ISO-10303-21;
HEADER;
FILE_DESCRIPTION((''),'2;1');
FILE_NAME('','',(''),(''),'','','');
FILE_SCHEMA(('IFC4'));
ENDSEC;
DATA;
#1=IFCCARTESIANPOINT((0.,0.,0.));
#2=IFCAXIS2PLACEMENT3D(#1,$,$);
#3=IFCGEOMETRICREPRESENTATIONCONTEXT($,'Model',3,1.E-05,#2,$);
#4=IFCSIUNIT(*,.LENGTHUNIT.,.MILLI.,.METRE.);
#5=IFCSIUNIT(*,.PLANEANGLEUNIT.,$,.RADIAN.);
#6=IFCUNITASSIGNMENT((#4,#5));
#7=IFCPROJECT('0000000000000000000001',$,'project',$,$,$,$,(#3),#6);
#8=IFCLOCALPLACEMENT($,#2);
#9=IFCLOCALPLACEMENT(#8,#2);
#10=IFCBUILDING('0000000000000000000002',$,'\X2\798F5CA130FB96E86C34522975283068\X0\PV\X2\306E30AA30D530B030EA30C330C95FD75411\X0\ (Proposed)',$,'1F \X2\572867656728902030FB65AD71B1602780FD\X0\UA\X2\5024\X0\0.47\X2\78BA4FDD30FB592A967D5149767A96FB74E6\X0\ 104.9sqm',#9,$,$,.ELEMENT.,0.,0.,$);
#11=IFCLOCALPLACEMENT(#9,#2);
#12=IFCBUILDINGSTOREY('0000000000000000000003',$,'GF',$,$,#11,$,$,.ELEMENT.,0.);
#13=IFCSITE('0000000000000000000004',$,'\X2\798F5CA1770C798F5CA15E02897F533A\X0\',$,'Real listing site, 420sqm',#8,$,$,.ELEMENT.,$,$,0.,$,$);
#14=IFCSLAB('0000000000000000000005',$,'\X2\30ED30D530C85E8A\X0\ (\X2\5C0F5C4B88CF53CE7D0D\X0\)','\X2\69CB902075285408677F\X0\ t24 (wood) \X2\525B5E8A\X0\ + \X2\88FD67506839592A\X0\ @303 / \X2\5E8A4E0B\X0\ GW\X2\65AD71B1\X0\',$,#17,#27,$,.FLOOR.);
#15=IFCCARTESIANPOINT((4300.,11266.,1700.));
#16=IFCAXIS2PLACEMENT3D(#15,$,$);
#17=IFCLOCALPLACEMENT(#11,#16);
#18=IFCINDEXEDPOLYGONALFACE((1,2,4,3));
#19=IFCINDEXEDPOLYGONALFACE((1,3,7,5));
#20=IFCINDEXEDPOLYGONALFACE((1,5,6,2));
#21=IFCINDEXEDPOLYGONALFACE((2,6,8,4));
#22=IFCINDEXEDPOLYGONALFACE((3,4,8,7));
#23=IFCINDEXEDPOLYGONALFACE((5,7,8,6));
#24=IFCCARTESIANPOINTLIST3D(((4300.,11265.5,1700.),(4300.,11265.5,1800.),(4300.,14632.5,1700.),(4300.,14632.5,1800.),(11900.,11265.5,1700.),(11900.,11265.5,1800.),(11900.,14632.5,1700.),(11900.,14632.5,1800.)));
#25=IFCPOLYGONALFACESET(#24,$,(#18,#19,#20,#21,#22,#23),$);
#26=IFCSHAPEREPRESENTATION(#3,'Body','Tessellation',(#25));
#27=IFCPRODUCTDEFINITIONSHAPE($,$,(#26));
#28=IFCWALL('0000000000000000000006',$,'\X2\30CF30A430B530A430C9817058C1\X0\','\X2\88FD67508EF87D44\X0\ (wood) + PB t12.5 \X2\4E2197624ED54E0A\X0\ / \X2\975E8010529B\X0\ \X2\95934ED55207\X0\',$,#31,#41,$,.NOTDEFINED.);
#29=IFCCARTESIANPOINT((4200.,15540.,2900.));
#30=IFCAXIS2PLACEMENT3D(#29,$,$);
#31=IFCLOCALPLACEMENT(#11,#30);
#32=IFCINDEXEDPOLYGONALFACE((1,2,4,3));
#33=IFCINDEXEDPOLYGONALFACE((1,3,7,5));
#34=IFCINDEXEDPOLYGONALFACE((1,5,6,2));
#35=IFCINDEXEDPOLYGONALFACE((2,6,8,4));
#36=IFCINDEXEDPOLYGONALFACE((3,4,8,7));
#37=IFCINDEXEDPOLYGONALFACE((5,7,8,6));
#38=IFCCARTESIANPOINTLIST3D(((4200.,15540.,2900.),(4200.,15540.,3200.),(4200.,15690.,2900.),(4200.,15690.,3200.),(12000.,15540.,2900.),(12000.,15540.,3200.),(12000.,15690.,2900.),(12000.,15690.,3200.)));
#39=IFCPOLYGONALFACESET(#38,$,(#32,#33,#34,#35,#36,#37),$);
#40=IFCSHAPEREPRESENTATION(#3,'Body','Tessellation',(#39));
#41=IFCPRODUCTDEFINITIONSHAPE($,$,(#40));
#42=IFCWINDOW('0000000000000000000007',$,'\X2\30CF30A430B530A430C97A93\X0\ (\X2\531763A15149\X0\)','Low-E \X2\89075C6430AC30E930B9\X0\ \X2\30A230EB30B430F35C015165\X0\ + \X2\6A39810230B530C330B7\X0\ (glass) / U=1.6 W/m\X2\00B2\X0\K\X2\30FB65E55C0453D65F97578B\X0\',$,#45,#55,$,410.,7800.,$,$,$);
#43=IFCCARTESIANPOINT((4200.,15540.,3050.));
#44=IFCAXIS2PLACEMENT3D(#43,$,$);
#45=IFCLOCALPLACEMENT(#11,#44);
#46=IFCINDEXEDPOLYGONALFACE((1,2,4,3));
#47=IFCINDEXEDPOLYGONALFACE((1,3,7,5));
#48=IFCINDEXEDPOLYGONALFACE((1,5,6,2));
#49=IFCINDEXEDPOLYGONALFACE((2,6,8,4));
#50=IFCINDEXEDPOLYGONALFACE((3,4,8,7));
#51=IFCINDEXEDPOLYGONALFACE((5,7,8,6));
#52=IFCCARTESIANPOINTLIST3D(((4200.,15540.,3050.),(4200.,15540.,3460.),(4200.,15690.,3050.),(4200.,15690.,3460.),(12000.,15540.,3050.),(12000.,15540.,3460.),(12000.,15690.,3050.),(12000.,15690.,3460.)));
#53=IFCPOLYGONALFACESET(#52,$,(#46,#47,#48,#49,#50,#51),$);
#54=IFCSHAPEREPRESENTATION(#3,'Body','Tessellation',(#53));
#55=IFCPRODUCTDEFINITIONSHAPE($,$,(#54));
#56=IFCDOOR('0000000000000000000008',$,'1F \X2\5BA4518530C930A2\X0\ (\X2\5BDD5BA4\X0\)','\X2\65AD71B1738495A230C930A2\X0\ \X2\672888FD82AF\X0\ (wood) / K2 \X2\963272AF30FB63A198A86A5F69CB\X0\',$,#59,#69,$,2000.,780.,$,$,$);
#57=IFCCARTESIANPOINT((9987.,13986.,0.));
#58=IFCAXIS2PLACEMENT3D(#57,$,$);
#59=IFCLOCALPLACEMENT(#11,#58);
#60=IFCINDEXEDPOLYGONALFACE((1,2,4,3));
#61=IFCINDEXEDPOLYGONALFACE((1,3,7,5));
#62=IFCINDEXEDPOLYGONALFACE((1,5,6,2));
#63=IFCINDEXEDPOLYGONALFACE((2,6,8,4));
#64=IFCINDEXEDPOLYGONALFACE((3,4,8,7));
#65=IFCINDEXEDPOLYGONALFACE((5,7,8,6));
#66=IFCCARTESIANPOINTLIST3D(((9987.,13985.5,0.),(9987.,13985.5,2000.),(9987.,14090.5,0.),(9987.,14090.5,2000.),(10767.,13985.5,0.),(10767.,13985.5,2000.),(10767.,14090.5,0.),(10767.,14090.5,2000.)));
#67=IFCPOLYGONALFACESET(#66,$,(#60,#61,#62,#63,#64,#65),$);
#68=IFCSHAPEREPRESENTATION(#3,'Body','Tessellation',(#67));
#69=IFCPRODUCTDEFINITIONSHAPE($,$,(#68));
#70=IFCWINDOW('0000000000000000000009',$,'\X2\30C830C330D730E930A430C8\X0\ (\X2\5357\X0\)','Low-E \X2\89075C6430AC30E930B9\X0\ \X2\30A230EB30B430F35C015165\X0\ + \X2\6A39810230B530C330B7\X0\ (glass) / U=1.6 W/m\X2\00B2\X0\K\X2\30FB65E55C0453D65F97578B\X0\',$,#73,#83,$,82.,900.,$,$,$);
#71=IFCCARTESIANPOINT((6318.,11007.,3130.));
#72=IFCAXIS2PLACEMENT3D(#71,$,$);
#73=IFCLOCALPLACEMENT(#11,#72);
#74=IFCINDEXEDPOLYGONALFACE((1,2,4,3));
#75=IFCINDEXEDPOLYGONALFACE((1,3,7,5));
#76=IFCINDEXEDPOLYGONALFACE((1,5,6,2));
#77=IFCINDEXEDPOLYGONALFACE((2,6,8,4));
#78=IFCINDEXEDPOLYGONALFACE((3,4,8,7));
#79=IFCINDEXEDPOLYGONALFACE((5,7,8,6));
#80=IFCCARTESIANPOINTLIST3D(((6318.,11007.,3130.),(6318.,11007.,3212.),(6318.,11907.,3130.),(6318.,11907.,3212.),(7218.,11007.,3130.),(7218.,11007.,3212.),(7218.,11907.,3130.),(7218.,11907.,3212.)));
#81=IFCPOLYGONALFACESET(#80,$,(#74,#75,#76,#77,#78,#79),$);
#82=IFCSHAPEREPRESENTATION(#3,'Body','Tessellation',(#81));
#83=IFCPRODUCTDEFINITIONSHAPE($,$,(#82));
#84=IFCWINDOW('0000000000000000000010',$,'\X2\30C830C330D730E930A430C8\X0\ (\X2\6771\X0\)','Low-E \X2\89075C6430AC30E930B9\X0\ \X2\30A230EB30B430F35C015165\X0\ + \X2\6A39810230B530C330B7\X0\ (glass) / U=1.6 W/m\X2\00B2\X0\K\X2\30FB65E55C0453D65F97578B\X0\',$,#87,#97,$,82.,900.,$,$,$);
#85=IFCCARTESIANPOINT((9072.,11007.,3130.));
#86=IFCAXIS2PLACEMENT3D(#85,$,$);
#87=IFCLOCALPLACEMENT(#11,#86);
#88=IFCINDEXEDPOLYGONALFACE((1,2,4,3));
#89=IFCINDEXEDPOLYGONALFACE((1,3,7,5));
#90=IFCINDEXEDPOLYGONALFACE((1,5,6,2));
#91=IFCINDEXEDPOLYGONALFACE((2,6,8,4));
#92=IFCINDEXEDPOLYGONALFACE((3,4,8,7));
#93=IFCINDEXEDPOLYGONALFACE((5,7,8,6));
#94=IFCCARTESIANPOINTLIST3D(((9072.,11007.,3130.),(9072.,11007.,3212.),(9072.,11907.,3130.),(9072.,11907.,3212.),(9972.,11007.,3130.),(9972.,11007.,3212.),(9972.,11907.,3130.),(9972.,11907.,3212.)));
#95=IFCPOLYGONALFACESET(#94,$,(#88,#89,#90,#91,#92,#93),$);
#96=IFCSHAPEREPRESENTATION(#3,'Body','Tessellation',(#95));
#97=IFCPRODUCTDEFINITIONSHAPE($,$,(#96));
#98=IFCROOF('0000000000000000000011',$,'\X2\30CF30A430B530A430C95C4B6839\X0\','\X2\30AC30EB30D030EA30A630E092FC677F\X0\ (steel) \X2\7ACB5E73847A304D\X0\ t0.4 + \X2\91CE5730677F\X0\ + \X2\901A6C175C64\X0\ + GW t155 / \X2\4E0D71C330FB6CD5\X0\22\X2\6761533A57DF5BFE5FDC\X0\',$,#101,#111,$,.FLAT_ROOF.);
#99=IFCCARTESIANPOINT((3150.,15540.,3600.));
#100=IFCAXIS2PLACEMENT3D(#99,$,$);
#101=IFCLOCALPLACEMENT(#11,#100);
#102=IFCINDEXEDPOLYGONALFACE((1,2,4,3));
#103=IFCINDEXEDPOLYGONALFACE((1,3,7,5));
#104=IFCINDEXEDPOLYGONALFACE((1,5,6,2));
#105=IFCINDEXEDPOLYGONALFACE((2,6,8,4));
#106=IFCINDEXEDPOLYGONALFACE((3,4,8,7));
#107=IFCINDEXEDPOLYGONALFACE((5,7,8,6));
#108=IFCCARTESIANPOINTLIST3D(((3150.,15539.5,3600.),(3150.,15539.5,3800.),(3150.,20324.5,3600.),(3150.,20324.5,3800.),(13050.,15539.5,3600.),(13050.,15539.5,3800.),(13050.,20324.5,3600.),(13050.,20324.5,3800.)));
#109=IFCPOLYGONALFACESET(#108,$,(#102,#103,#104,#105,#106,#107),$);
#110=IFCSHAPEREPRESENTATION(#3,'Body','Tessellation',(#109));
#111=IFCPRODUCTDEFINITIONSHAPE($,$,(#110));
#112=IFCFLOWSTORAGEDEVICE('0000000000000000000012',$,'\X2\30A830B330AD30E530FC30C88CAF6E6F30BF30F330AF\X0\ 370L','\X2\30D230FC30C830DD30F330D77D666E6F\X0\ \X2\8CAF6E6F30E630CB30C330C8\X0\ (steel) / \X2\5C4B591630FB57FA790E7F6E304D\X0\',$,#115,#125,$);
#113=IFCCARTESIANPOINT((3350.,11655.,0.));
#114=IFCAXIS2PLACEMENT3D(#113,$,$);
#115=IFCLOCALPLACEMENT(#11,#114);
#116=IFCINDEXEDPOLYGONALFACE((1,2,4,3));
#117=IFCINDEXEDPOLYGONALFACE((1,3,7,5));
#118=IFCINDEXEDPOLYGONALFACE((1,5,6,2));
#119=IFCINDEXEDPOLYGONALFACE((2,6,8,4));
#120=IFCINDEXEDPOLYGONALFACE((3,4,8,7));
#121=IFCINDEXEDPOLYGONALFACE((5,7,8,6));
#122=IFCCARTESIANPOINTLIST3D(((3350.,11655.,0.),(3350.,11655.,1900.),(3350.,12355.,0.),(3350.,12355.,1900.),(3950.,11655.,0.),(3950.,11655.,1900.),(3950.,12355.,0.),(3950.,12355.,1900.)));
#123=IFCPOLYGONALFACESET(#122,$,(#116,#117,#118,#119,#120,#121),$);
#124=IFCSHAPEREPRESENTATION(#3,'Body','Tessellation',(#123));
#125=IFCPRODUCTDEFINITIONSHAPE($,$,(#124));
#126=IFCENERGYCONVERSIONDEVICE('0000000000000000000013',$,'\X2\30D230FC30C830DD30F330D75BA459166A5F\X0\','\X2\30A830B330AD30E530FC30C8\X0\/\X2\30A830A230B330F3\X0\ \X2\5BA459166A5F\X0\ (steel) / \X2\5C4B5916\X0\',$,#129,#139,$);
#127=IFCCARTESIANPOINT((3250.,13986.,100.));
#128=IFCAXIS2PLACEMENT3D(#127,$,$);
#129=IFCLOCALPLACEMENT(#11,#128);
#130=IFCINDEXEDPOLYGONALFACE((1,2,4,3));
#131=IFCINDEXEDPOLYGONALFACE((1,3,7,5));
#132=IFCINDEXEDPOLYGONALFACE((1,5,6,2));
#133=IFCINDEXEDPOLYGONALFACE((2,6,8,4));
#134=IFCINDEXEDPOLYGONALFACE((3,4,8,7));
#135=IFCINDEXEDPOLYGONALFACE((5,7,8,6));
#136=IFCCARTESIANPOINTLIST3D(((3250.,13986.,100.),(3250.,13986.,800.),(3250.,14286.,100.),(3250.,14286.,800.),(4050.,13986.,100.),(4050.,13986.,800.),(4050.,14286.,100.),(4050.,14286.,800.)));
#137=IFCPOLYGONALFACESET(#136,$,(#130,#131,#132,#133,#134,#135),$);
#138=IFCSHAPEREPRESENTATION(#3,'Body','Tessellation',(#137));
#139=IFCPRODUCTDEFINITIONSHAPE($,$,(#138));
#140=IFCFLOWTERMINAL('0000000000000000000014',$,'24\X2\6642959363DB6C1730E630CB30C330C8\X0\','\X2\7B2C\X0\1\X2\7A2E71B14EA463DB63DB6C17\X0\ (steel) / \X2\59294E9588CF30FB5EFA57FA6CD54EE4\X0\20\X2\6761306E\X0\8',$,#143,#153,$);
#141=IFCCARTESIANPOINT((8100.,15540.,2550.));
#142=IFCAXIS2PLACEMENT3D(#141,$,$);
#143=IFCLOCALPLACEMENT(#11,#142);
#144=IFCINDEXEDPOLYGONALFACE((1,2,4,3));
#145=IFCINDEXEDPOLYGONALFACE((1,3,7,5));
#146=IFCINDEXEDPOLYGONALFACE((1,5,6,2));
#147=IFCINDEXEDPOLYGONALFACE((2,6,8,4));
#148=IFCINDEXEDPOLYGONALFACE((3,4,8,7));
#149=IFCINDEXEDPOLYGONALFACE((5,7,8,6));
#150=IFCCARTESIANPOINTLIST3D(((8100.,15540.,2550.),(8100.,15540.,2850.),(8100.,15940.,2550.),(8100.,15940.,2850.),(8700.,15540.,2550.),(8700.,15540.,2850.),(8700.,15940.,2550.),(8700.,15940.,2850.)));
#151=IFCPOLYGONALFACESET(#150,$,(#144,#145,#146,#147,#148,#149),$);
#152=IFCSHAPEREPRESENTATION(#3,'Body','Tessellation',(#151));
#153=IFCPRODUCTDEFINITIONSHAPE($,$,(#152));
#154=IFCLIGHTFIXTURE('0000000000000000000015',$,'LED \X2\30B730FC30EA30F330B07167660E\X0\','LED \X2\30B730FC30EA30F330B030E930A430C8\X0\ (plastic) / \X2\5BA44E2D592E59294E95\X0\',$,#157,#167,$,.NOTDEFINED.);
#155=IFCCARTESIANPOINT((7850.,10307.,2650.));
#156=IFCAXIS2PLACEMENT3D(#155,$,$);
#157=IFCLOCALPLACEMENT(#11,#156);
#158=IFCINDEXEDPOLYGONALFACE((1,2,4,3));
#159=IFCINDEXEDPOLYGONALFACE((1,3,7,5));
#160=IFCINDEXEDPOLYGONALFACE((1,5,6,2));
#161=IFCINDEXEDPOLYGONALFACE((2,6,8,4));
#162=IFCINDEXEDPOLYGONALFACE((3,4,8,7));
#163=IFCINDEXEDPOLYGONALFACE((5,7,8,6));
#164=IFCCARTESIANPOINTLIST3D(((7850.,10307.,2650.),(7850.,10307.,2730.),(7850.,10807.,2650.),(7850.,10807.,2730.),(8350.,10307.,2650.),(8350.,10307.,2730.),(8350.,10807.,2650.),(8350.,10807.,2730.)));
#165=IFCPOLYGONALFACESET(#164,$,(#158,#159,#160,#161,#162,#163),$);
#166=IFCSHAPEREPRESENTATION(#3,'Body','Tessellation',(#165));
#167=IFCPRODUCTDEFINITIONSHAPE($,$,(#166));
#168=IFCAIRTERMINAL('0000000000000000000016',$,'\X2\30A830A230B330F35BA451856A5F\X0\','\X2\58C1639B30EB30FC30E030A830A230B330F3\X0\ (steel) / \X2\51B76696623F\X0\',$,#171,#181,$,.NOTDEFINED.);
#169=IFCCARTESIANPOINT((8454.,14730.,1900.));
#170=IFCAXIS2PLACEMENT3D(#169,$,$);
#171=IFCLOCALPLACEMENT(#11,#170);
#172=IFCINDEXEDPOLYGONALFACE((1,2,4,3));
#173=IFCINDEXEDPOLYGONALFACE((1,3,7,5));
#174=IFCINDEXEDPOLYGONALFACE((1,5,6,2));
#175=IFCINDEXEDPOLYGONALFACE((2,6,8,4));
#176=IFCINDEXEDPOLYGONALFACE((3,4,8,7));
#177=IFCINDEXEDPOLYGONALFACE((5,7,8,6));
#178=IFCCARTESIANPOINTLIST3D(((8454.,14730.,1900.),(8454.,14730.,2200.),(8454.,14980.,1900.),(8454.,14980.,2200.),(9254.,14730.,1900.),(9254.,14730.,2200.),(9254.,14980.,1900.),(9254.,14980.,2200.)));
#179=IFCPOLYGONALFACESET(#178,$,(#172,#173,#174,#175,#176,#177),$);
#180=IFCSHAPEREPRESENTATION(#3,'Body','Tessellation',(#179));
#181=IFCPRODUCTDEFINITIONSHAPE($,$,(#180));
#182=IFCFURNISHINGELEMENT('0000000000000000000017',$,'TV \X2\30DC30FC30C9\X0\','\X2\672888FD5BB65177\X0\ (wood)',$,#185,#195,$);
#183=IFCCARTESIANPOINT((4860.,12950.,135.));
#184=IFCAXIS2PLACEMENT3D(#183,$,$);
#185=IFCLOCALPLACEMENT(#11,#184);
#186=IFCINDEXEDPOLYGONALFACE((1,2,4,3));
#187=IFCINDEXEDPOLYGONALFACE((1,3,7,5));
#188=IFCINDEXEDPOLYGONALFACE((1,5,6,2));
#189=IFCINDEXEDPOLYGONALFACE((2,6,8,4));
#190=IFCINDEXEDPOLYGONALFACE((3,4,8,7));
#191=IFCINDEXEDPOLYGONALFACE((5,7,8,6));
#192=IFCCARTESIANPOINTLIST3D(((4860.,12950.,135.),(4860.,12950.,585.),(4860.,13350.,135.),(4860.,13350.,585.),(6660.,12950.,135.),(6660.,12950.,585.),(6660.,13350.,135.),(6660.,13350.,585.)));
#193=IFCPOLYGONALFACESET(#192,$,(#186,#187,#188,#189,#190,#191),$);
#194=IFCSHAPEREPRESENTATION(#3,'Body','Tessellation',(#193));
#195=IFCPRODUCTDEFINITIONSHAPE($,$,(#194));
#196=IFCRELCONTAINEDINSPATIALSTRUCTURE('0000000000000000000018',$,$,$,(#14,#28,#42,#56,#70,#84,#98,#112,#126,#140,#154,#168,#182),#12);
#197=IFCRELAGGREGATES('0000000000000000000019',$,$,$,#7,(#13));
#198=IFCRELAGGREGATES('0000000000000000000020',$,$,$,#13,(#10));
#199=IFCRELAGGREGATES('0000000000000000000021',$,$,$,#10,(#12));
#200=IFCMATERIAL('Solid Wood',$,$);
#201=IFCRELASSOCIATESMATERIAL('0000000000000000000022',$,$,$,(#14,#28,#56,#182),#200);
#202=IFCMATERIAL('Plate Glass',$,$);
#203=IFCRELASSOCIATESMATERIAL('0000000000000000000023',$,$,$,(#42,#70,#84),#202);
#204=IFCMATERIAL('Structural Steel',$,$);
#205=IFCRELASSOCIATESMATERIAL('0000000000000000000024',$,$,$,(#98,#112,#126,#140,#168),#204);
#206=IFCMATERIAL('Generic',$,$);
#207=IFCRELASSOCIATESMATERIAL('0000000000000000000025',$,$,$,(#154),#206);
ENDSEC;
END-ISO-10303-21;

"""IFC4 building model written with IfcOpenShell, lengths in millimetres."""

from ifc_helpers import new_model, si_unit, frame, frame_2d, origin, place, context, project, spatial, rectangle, extrude, material, element, fill, save


model = new_model("IFC4")

# Units and contexts
model_context = context("Model", 3, precision=1e-05, world=origin())
ifc_project = project(units=[si_unit("LENGTHUNIT", "METRE", prefix="MILLI"), si_unit("PLANEANGLEUNIT", "RADIAN")], contexts=[model_context])

# Site, building, storey
site_placement = place(None, origin())
site = spatial("IfcSite", under=ifc_project, at=site_placement, Name="福岡県福岡市西区", ObjectType="Real listing site, 420sqm", CompositionType="ELEMENT", RefElevation=0.0)
building_placement = place(site_placement, origin())
building = spatial("IfcBuilding", under=site, at=building_placement, Name="福岡・雨水利用とPVのオフグリッド志向 (Proposed)", ObjectType="1F 在来木造・断熱性能UA値0.47確保・太陽光発電瓦 104.9sqm", CompositionType="ELEMENT", ElevationOfRefHeight=0.0, ElevationOfTerrain=0.0)
storey_placement = place(building_placement, origin())
storey = spatial("IfcBuildingStorey", under=building, at=storey_placement, Name="GF", CompositionType="ELEMENT", Elevation=0.0)

# Shared definitions
ifc_material_1 = material(Name="Solid Wood")

# Slab
slab_placement = place(storey_placement, frame((4300.0, 11266.0, 1700.0)))
element("IfcSlab", 1, at=slab_placement, inside=storey, material=ifc_material_1, Name="ロフト床 (小屋裏収納)", Description="構造用合板 t24 (wood) 剛床 + 製材根太 @303 / 床下 GW断熱", PredefinedType="FLOOR", context=model_context, shape_type="SweptSolid", body=[
    extrude(rectangle(XDim=7600.0, YDim=3367.0, at=frame_2d((3800.0, 1683.0))), frame((4300.0, 11266.0, 1700.0)), (0.0, 0.0, 1.0), 100.0),
])

# Wall, opening, window
wall_1_placement = place(storey_placement, frame((4200.0, 15540.0, 2900.0)))
wall_1 = element("IfcWall", 2, at=wall_1_placement, inside=storey, material=ifc_material_1, Name="ハイサイド腰壁", Description="製材軸組 (wood) + PB t12.5 両面仕上 / 非耐力 間仕切", PredefinedType="NOTDEFINED", context=model_context, shape_type="SweptSolid", body=[
    extrude(rectangle(XDim=7800.0, YDim=150.0, at=frame_2d((3900.0, 75.0))), frame((4200.0, 15540.0, 2900.0)), (0.0, 0.0, 1.0), 700.0),
])
opening_1_placement = place(storey_placement, frame((4200.0, 15540.0, 3050.0)))
opening_1 = element("IfcOpeningElement", 3, at=opening_1_placement, cuts=wall_1, PredefinedType="NOTDEFINED", context=model_context, shape_type="SweptSolid", body=[
    extrude(rectangle(XDim=7800.0, YDim=150.0, at=frame_2d((3900.0, 75.0))), frame((4200.0, 15540.0, 3050.0)), (0.0, 0.0, 1.0), 410.0),
])
ifc_material_2 = material(Name="Plate Glass")
window_1_placement = place(storey_placement, frame((4200.0, 15540.0, 3050.0)))
window_1 = element("IfcWindow", 4, at=window_1_placement, inside=storey, material=ifc_material_2, Name="ハイサイド窓 (北採光)", Description="Low-E 複層ガラス アルゴン封入 + 樹脂サッシ (glass) / U=1.6 W/m²K・日射取得型", OverallHeight=410.0, OverallWidth=7800.0, context=model_context, shape_type="SweptSolid", body=[
    extrude(rectangle(XDim=7800.0, YDim=150.0, at=frame_2d((3900.0, 75.0))), frame((4200.0, 15540.0, 3050.0)), (0.0, 0.0, 1.0), 410.0),
])
fill(opening_1, window_1)

# Door
door_1_placement = place(storey_placement, frame((9987.0, 13986.0, 0.0)))
element("IfcDoor", 5, at=door_1_placement, inside=storey, material=ifc_material_1, Name="1F 室内ドア (寝室)", Description="断熱玄関ドア 木製芯 (wood) / K2 防犯・採風機構", OverallHeight=2000.0, OverallWidth=780.0, context=model_context, shape_type="SweptSolid", body=[
    extrude(rectangle(XDim=780.0, YDim=105.0, at=frame_2d((390.0, 52.0))), frame((9987.0, 13986.0, 0.0)), (0.0, 0.0, 1.0), 2000.0),
])

# Windows
window_2_placement = place(storey_placement, frame((6318.0, 11007.0, 3130.0)))
element("IfcWindow", 6, at=window_2_placement, inside=storey, material=ifc_material_2, Name="トップライト (南)", Description="Low-E 複層ガラス アルゴン封入 + 樹脂サッシ (glass) / U=1.6 W/m²K・日射取得型", OverallHeight=82.0, OverallWidth=900.0, context=model_context, shape_type="SweptSolid", body=[
    extrude(rectangle(XDim=900.0, YDim=900.0, at=frame_2d((450.0, 450.0))), frame((6318.0, 11007.0, 3130.0)), (0.0, 0.0, 1.0), 82.0),
])
window_3_placement = place(storey_placement, frame((9072.0, 11007.0, 3130.0)))
element("IfcWindow", 7, at=window_3_placement, inside=storey, material=ifc_material_2, Name="トップライト (東)", Description="Low-E 複層ガラス アルゴン封入 + 樹脂サッシ (glass) / U=1.6 W/m²K・日射取得型", OverallHeight=82.0, OverallWidth=900.0, context=model_context, shape_type="SweptSolid", body=[
    extrude(rectangle(XDim=900.0, YDim=900.0, at=frame_2d((450.0, 450.0))), frame((9072.0, 11007.0, 3130.0)), (0.0, 0.0, 1.0), 82.0),
])

# Roof
ifc_material_3 = material(Name="Structural Steel")
roof_placement = place(storey_placement, frame((3150.0, 15540.0, 3600.0)))
element("IfcRoof", 8, at=roof_placement, inside=storey, material=ifc_material_3, Name="ハイサイド屋根", Description="ガルバリウム鋼板 (steel) 立平葺き t0.4 + 野地板 + 通気層 + GW t155 / 不燃・法22条区域対応", PredefinedType="FLAT_ROOF", context=model_context, shape_type="SweptSolid", body=[
    extrude(rectangle(XDim=9900.0, YDim=4785.0, at=frame_2d((4950.0, 2392.0))), frame((3150.0, 15540.0, 3600.0)), (0.0, 0.0, 1.0), 200.0),
])

# Flow storage device
flow_storage_device_placement = place(storey_placement, frame((3350.0, 11655.0, 0.0)))
element("IfcFlowStorageDevice", 9, at=flow_storage_device_placement, inside=storey, material=ifc_material_3, Name="エコキュート貯湯タンク 370L", Description="ヒートポンプ給湯 貯湯ユニット (steel) / 屋外・基礎置き", context=model_context, shape_type="SweptSolid", body=[
    extrude(rectangle(XDim=600.0, YDim=700.0, at=frame_2d((300.0, 350.0))), frame((3350.0, 11655.0, 0.0)), (0.0, 0.0, 1.0), 1900.0),
])

# Energy conversion device
energy_conversion_device_placement = place(storey_placement, frame((3250.0, 13986.0, 100.0)))
element("IfcEnergyConversionDevice", 10, at=energy_conversion_device_placement, inside=storey, material=ifc_material_3, Name="ヒートポンプ室外機", Description="エコキュート/エアコン 室外機 (steel) / 屋外", context=model_context, shape_type="SweptSolid", body=[
    extrude(rectangle(XDim=800.0, YDim=300.0, at=frame_2d((400.0, 150.0))), frame((3250.0, 13986.0, 100.0)), (0.0, 0.0, 1.0), 700.0),
])

# Flow terminal
flow_terminal_placement = place(storey_placement, frame((8100.0, 15540.0, 2550.0)))
element("IfcFlowTerminal", 11, at=flow_terminal_placement, inside=storey, material=ifc_material_3, Name="24時間換気ユニット", Description="第1種熱交換換気 (steel) / 天井裏・建基法令20条の8", context=model_context, shape_type="SweptSolid", body=[
    extrude(rectangle(XDim=600.0, YDim=400.0, at=frame_2d((300.0, 200.0))), frame((8100.0, 15540.0, 2550.0)), (0.0, 0.0, 1.0), 300.0),
])

# Light fixture
ifc_material_4 = material(Name="Generic")
light_fixture_placement = place(storey_placement, frame((7850.0, 10307.0, 2650.0)))
element("IfcLightFixture", 12, at=light_fixture_placement, inside=storey, material=ifc_material_4, Name="LED シーリング照明", Description="LED シーリングライト (plastic) / 室中央天井", PredefinedType="NOTDEFINED", context=model_context, shape_type="SweptSolid", body=[
    extrude(rectangle(XDim=500.0, YDim=500.0, at=frame_2d((250.0, 250.0))), frame((7850.0, 10307.0, 2650.0)), (0.0, 0.0, 1.0), 80.0),
])

# Air terminal
air_terminal_placement = place(storey_placement, frame((8454.0, 14730.0, 1900.0)))
element("IfcAirTerminal", 13, at=air_terminal_placement, inside=storey, material=ifc_material_3, Name="エアコン室内機", Description="壁掛ルームエアコン (steel) / 冷暖房", PredefinedType="NOTDEFINED", context=model_context, shape_type="SweptSolid", body=[
    extrude(rectangle(XDim=800.0, YDim=250.0, at=frame_2d((400.0, 125.0))), frame((8454.0, 14730.0, 1900.0)), (0.0, 0.0, 1.0), 300.0),
])

# Furnishing element
furnishing_placement = place(storey_placement, frame((4860.0, 12950.0, 135.0)))
element("IfcFurnishingElement", 14, at=furnishing_placement, inside=storey, material=ifc_material_1, Name="TV ボード", Description="木製家具 (wood)", context=model_context, shape_type="SweptSolid", body=[
    extrude(rectangle(XDim=1800.0, YDim=400.0, at=frame_2d((900.0, 200.0))), frame((4860.0, 12950.0, 135.0)), (0.0, 0.0, 1.0), 450.0),
])

save(model, "model.ifc")
